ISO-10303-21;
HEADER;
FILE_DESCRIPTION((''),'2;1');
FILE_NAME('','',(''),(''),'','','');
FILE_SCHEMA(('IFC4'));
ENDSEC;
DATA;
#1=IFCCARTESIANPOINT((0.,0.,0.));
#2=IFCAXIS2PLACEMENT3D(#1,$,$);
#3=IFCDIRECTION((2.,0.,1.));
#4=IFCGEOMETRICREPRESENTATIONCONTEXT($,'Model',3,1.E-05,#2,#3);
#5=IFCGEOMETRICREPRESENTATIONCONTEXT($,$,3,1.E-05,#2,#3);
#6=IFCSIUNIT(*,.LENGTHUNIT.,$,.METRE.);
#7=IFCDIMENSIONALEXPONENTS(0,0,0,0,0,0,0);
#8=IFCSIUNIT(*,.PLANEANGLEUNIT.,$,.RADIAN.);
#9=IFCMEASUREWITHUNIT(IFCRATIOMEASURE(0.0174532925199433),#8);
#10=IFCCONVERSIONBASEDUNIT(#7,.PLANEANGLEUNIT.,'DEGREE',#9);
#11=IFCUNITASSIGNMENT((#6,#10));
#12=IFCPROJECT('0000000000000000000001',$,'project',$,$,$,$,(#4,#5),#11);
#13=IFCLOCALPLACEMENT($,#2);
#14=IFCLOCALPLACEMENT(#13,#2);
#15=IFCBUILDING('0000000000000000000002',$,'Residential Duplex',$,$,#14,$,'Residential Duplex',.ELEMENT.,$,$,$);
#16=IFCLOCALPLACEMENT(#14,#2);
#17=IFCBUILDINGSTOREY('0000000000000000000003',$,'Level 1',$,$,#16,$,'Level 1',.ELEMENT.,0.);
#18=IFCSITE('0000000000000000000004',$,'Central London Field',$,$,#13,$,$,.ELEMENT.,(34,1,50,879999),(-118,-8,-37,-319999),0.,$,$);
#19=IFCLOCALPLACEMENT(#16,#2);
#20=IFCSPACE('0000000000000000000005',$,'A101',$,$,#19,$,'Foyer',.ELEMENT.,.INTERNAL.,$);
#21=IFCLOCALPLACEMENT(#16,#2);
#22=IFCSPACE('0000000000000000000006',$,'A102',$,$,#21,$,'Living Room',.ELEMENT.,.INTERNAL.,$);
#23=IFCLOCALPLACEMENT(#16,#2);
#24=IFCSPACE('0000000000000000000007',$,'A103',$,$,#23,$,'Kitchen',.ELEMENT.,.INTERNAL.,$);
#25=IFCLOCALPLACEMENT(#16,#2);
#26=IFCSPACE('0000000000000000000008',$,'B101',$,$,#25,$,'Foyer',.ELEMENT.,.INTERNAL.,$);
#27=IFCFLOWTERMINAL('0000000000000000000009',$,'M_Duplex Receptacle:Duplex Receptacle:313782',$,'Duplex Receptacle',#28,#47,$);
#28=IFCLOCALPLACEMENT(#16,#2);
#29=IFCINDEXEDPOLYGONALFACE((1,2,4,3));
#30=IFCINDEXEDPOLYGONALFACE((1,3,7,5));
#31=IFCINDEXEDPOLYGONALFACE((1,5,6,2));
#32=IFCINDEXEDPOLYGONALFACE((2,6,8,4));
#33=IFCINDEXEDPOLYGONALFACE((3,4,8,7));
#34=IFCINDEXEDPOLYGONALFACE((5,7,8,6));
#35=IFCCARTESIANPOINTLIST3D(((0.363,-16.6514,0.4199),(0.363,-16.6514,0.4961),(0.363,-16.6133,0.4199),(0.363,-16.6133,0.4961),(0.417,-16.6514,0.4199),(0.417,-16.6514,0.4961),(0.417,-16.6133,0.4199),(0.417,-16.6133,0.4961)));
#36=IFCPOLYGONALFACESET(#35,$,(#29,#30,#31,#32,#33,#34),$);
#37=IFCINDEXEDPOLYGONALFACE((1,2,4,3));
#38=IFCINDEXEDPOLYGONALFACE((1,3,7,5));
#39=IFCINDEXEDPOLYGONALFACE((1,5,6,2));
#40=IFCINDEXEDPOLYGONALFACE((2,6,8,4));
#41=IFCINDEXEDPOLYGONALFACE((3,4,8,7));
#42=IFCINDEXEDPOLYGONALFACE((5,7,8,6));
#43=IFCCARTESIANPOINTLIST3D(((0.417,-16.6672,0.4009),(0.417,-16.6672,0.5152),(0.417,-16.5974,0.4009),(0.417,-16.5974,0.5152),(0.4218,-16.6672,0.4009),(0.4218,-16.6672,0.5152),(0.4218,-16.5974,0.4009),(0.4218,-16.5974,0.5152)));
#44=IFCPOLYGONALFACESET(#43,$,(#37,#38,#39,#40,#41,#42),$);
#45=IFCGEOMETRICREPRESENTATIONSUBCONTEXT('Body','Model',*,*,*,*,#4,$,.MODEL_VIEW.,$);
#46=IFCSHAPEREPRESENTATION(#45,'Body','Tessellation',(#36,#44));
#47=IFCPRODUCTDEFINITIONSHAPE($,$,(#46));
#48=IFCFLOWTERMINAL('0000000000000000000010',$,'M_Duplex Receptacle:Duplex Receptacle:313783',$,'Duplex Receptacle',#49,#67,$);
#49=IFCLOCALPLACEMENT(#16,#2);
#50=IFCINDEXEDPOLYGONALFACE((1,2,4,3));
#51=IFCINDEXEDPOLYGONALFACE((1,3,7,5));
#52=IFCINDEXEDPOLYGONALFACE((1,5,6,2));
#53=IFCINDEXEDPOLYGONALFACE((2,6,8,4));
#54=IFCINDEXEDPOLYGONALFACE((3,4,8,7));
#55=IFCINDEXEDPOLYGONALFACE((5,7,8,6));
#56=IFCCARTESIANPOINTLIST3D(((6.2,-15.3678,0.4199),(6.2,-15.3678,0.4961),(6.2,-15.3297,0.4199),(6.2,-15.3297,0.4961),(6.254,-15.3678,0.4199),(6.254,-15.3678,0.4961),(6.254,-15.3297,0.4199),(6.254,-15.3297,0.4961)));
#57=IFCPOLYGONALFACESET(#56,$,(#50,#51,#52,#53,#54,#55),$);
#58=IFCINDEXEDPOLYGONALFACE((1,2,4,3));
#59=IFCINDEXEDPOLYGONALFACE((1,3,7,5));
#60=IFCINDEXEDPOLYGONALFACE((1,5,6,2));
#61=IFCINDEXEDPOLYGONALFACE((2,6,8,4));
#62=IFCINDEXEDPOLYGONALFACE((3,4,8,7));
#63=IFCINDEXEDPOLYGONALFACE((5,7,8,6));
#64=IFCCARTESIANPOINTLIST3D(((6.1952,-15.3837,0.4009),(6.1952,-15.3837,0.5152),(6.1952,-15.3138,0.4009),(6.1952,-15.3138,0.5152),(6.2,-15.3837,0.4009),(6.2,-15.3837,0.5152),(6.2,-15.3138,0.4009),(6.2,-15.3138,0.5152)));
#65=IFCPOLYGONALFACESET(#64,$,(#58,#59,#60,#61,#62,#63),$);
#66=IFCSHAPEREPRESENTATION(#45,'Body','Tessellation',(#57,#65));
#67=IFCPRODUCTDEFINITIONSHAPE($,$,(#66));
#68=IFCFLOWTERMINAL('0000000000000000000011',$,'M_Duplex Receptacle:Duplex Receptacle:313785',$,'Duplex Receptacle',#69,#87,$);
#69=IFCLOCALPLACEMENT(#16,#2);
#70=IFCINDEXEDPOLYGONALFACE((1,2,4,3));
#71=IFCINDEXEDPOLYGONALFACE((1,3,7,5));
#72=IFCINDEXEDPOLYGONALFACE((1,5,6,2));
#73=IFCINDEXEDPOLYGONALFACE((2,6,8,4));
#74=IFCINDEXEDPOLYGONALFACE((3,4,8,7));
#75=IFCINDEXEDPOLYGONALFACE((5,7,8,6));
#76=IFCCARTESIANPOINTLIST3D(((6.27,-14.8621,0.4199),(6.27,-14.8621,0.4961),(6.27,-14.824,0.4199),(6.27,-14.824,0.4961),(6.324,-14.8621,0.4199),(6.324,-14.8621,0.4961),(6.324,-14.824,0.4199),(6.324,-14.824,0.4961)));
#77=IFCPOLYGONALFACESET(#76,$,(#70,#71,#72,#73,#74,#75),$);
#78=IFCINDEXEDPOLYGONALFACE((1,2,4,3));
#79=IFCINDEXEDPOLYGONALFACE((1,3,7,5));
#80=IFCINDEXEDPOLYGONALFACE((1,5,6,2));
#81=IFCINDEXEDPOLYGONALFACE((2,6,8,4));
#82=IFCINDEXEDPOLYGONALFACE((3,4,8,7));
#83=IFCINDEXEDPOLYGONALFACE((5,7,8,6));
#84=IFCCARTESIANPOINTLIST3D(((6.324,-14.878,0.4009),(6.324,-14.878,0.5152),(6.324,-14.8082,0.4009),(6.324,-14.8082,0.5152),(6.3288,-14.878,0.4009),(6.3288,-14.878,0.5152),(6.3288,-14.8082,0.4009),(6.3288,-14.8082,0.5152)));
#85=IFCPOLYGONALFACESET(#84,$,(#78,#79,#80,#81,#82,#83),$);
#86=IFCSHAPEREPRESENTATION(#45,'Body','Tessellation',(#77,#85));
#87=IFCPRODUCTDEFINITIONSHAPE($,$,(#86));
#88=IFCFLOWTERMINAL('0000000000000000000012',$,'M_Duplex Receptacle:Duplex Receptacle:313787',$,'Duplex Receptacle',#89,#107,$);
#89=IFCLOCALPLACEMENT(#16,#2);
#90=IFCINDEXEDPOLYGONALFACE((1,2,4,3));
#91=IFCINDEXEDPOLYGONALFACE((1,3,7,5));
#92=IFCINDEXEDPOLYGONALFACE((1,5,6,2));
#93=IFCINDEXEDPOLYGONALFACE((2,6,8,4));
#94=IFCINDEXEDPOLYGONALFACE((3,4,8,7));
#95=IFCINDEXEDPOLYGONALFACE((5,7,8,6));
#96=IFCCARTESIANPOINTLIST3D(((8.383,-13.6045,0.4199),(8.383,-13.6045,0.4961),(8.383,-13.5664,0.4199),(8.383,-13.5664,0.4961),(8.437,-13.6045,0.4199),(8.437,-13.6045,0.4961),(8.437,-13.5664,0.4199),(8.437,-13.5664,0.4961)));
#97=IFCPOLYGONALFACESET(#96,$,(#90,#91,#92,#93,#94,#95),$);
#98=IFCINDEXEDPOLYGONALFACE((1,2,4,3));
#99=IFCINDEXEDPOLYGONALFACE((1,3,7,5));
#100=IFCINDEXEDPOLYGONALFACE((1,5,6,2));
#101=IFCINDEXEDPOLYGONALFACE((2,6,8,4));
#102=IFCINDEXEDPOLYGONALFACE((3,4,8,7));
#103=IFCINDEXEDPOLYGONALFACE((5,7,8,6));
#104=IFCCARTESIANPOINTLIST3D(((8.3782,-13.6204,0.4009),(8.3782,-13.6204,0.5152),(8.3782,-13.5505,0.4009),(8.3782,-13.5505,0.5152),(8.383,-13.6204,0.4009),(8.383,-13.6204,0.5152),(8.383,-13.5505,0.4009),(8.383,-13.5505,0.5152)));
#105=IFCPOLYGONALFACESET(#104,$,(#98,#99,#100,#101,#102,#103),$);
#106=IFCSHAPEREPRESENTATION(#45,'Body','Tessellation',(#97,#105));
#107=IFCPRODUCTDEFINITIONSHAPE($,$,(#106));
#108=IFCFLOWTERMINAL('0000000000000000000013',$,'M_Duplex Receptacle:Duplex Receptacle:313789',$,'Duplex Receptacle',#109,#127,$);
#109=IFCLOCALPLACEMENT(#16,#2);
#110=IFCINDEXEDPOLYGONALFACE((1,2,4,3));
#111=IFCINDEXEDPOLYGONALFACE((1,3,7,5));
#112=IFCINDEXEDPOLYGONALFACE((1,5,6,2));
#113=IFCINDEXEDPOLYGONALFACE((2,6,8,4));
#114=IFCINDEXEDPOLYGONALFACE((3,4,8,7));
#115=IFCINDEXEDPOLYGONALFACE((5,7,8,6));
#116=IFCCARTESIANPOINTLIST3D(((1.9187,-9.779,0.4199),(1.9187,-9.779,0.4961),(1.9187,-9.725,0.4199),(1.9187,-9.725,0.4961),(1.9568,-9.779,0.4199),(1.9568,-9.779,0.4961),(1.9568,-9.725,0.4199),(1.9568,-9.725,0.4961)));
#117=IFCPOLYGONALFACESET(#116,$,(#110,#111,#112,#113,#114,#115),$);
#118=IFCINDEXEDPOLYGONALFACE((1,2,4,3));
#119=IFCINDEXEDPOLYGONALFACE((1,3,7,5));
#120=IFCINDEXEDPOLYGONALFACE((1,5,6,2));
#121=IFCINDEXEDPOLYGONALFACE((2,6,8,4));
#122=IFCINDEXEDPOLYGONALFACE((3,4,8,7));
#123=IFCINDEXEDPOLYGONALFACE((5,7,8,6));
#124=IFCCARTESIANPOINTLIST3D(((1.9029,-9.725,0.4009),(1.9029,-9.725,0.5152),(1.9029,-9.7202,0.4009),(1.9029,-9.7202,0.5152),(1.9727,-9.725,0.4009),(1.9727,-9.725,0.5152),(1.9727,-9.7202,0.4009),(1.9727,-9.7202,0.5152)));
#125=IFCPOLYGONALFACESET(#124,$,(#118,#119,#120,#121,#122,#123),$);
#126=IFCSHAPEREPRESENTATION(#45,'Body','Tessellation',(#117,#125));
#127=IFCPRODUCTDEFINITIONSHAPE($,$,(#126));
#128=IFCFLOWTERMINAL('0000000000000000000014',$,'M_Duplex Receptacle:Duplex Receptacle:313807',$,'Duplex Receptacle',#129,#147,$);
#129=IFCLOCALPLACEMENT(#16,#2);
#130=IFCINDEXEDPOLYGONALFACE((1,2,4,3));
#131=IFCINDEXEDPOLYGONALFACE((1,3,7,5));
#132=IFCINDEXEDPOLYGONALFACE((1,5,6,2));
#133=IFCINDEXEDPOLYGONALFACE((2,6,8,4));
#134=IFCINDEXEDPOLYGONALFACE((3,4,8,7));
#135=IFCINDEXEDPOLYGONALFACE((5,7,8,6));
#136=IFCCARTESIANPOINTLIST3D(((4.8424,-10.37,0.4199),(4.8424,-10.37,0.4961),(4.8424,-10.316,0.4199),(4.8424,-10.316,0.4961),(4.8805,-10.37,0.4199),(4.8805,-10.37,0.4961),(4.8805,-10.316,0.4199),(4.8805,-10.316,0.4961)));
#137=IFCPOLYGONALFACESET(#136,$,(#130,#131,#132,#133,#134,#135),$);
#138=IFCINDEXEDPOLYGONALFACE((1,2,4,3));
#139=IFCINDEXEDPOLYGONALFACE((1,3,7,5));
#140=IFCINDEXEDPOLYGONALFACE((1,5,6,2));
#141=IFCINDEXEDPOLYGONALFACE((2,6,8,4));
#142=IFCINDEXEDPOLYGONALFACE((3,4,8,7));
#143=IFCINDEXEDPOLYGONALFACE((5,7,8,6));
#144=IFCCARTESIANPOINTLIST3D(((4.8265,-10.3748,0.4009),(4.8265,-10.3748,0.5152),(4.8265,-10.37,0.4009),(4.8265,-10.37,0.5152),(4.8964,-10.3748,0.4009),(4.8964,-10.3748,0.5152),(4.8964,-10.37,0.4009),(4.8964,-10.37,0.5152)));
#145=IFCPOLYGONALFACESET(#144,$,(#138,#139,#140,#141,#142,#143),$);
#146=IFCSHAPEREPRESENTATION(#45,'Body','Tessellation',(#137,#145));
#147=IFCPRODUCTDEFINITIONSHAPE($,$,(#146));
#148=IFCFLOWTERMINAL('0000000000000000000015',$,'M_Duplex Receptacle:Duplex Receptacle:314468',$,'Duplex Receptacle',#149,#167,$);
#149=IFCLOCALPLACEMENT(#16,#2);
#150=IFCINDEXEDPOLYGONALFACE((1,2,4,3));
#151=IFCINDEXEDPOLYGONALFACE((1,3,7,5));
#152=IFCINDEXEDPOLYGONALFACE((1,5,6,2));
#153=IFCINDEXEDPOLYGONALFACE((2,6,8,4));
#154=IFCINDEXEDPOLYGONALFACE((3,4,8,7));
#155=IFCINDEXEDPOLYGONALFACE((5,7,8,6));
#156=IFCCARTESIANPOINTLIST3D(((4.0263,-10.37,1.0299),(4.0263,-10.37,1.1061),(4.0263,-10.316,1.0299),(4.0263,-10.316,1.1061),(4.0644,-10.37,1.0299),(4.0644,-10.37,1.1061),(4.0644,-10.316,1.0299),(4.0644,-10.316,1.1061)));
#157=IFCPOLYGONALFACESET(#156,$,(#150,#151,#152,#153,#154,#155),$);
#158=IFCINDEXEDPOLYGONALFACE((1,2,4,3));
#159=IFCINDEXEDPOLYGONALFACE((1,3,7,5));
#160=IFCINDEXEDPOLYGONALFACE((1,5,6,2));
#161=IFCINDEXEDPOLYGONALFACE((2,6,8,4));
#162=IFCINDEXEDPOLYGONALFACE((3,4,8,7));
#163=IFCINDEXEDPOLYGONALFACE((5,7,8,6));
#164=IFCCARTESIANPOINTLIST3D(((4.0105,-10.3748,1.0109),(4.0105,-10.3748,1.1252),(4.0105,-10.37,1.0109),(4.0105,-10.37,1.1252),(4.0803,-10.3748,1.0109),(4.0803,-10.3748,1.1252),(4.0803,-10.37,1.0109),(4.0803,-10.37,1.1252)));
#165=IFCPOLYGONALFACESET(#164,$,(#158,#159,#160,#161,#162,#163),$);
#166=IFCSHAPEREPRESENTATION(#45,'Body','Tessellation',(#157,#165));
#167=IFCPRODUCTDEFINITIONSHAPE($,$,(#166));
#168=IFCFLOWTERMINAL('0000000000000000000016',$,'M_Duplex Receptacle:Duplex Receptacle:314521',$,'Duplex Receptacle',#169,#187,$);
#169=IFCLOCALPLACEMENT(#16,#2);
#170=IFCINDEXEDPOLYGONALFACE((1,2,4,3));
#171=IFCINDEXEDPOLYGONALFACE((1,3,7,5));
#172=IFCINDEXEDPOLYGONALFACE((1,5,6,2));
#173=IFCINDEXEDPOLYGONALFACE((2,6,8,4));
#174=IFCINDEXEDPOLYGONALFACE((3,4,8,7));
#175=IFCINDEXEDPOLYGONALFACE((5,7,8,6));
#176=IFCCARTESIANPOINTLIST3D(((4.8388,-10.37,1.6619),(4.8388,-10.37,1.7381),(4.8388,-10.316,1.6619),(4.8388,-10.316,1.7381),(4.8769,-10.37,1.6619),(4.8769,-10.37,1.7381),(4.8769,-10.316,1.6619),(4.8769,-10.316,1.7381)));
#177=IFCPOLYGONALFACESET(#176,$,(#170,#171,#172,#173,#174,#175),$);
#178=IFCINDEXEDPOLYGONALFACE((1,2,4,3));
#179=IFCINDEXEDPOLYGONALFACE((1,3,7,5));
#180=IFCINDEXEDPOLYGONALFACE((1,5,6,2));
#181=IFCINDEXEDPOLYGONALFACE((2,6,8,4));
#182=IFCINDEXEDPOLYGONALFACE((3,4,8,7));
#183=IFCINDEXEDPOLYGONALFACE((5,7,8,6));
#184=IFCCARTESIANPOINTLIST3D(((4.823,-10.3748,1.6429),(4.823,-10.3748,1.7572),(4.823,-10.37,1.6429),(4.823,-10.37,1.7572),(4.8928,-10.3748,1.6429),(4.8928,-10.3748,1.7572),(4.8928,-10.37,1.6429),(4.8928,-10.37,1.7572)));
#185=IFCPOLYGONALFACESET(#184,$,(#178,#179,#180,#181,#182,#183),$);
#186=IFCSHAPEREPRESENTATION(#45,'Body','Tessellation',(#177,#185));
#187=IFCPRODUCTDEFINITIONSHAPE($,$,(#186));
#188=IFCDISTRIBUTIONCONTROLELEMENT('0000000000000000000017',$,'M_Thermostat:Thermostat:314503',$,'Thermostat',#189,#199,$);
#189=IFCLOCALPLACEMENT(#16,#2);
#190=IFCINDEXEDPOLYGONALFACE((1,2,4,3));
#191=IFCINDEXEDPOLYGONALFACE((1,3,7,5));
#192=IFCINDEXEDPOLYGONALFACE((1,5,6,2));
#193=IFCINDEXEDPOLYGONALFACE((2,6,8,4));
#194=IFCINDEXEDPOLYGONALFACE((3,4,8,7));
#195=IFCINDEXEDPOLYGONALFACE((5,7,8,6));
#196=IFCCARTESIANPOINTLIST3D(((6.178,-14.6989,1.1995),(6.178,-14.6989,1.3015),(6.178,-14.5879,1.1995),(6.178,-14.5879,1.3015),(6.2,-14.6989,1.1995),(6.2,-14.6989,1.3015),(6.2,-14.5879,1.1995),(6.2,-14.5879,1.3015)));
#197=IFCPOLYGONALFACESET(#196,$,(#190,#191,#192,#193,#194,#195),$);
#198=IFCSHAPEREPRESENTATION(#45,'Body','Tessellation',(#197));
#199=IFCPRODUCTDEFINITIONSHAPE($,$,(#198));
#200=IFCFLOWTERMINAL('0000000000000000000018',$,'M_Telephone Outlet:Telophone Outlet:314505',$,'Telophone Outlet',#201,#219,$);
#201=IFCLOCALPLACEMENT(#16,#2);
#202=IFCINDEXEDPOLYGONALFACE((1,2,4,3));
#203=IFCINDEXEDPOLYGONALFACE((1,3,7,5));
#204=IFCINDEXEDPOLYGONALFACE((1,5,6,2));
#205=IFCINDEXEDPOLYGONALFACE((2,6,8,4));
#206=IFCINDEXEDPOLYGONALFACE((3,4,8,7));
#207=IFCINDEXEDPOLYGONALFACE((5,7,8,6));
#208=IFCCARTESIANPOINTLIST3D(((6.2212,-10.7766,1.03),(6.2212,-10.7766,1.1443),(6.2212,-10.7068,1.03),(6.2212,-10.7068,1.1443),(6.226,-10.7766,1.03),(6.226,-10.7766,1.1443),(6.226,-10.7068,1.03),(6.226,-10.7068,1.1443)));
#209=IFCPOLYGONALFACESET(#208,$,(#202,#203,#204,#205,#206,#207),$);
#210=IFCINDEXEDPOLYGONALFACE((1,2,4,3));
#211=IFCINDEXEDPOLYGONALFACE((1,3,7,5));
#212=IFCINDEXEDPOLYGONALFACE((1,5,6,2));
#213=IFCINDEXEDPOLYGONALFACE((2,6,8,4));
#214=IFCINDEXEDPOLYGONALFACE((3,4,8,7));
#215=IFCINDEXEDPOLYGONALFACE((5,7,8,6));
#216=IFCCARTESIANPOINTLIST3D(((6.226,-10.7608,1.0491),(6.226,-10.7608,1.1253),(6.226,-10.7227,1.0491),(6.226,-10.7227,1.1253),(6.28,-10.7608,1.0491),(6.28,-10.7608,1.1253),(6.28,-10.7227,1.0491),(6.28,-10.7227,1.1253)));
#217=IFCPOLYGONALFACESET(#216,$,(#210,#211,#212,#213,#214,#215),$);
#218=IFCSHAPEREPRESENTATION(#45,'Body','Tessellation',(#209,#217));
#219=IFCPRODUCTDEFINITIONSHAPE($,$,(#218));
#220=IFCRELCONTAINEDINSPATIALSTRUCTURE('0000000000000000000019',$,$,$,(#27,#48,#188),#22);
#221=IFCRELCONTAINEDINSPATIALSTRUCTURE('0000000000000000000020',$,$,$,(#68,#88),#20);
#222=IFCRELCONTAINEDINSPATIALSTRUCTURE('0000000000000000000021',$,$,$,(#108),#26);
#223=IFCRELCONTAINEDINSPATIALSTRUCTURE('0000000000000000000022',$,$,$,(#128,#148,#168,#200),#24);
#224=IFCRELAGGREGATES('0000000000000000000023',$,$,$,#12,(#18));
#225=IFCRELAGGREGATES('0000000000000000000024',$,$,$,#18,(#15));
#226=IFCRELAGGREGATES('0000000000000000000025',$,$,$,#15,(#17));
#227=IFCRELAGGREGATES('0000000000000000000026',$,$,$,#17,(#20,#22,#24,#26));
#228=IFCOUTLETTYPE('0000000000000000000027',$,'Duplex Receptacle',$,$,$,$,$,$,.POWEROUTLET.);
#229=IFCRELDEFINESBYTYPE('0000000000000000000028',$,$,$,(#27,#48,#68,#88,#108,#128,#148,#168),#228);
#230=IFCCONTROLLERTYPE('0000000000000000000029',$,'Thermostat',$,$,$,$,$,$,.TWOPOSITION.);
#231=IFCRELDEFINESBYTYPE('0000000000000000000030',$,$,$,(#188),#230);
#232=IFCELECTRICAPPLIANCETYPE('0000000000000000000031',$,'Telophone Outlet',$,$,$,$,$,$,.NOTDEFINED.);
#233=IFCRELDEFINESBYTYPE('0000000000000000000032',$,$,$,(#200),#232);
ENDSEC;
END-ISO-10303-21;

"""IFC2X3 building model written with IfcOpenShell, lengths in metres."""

from ifc_helpers import new_model, entity, si_unit, converted_unit, direction, frame, frame_2d, origin, origin_2d_with_axis, place, context, subcontext, project, spatial, rectangle, extrude, source, transform, mapped, type_object, type_shapes, element, save


model = new_model("IFC2X3")

# Units and contexts
model_context = context("Model", 3, precision=1e-05, world=origin(), true_north=direction((2.0, 0.0, 1.0)))
context_of_model = context(None, 3, precision=1e-05, world=origin(), true_north=direction((2.0, 0.0, 1.0)))
body_context = subcontext(model_context, "Body", "Model", "MODEL_VIEW")
ifc_project = project(units=[si_unit("LENGTHUNIT", "METRE"), converted_unit("PLANEANGLEUNIT", "DEGREE", entity("IfcRatioMeasure", 0.0174532925199433), si_unit("PLANEANGLEUNIT", "RADIAN"), dimensions=[0, 0, 0, 0, 0, 0, 0])], contexts=[model_context, context_of_model])

# Site, building, storey, space
site_placement = place(None, origin())
site = spatial("IfcSite", under=ifc_project, at=site_placement, Name="Central London Field", CompositionType="ELEMENT", RefLatitude=(34, 1, 50, 879999), RefLongitude=(-118, -8, -37, -319999), RefElevation=0.0)
building_placement = place(site_placement, origin())
building = spatial("IfcBuilding", under=site, at=building_placement, Name="Residential Duplex", LongName="Residential Duplex", CompositionType="ELEMENT")
storey_placement = place(building_placement, origin())
storey = spatial("IfcBuildingStorey", under=building, at=storey_placement, Name="Level 1", LongName="Level 1", CompositionType="ELEMENT", Elevation=0.0)
space_1_placement = place(storey_placement, origin())
space_1 = spatial("IfcSpace", under=storey, at=space_1_placement, Name="A101", LongName="Foyer", CompositionType="ELEMENT", InteriorOrExteriorSpace="INTERNAL")

# Shared definitions
space_2_placement = place(storey_placement, origin())
space_2 = spatial("IfcSpace", under=storey, at=space_2_placement, Name="A102", LongName="Living Room", CompositionType="ELEMENT", InteriorOrExteriorSpace="INTERNAL")

# Shared definitions
outlet_type = type_object("IfcOutletType", Name="Duplex Receptacle", PredefinedType="POWEROUTLET")
shared_shape_1 = source(origin(), body_context, "Body", "SweptSolid", [
    extrude(rectangle(XDim=0.0381, YDim=0.0762, at=origin_2d_with_axis()), frame((0.0, 0.0, -0.054), z_axis=(0.0, 0.0, 1.0), x_axis=(-1.0, 0.0, 0.0)), (0.0, 0.0, 1.0), 0.054),
    extrude(rectangle(XDim=0.0698, YDim=0.1143, at=frame_2d((0.0, 0.0), x_axis=(1.0, 0.0))), frame((0.0, 0.0, 0.0), z_axis=(0.0, 0.0, 1.0), x_axis=(-1.0, 0.0, 0.0)), (0.0, 0.0, 1.0), 0.0048),
])
type_shapes(outlet_type, [shared_shape_1])

# Shared definitions
space_3_placement = place(storey_placement, origin())
space_3 = spatial("IfcSpace", under=storey, at=space_3_placement, Name="A103", LongName="Kitchen", CompositionType="ELEMENT", InteriorOrExteriorSpace="INTERNAL")

# Flow terminals
for number, where, z_axis, x_axis, name in (
    (1, (0.417, -16.6323, 0.458), (1.0, 0.0, 0.0), (0.0, 1.0, 0.0), "M_Duplex Receptacle:Duplex Receptacle:313782"),
    (2, (6.2, -15.3487, 0.458), (-1.0, 0.0, 0.0), (0.0, -1.0, 0.0), "M_Duplex Receptacle:Duplex Receptacle:313783"),
):
    element("IfcFlowTerminal", number, at=place(space_2_placement, frame(where, z_axis=z_axis, x_axis=x_axis)), inside=space_2, type_object=outlet_type, Name=name, ObjectType="Duplex Receptacle", context=body_context, shape_type="MappedRepresentation", body=[
        mapped(shared_shape_1, transform((0.0, 0.0, 0.0), scale=1.0)),
    ])
for number, where, z_axis, x_axis, name in (
    (3, (6.324, -14.8431, 0.458), (1.0, 0.0, 0.0), (0.0, 1.0, 0.0), "M_Duplex Receptacle:Duplex Receptacle:313785"),
    (4, (8.383, -13.5854, 0.458), (-1.0, 0.0, 0.0), (0.0, -1.0, 0.0), "M_Duplex Receptacle:Duplex Receptacle:313787"),
):
    element("IfcFlowTerminal", number, at=place(space_1_placement, frame(where, z_axis=z_axis, x_axis=x_axis)), inside=space_1, type_object=outlet_type, Name=name, ObjectType="Duplex Receptacle", context=body_context, shape_type="MappedRepresentation", body=[
        mapped(shared_shape_1, transform((0.0, 0.0, 0.0), scale=1.0)),
    ])

# Shared definitions
space_4_placement = place(storey_placement, origin())
space_4 = spatial("IfcSpace", under=storey, at=space_4_placement, Name="B101", LongName="Foyer", CompositionType="ELEMENT", InteriorOrExteriorSpace="INTERNAL")

# Flow terminals
flow_terminal_1_placement = place(space_4_placement, frame((1.9378, -9.725, 0.458), z_axis=(0.0, 1.0, 0.0), x_axis=(-1.0, 0.0, 0.0)))
element("IfcFlowTerminal", 5, at=flow_terminal_1_placement, inside=space_4, type_object=outlet_type, Name="M_Duplex Receptacle:Duplex Receptacle:313789", ObjectType="Duplex Receptacle", context=body_context, shape_type="MappedRepresentation", body=[
    mapped(shared_shape_1, transform((0.0, 0.0, 0.0), scale=1.0)),
])
for number, where, z_axis, x_axis, name in (
    (6, (4.8615, -10.37, 0.458), (0.0, -1.0, 0.0), (1.0, 0.0, 0.0), "M_Duplex Receptacle:Duplex Receptacle:313807"),
    (7, (4.0454, -10.37, 1.068), (0.0, -1.0, 0.0), (1.0, 0.0, 0.0), "M_Duplex Receptacle:Duplex Receptacle:314468"),
    (8, (4.8579, -10.37, 1.7), (0.0, -1.0, 0.0), (1.0, 0.0, 0.0), "M_Duplex Receptacle:Duplex Receptacle:314521"),
):
    element("IfcFlowTerminal", number, at=place(space_3_placement, frame(where, z_axis=z_axis, x_axis=x_axis)), inside=space_3, type_object=outlet_type, Name=name, ObjectType="Duplex Receptacle", context=body_context, shape_type="MappedRepresentation", body=[
        mapped(shared_shape_1, transform((0.0, 0.0, 0.0), scale=1.0)),
    ])

# Distribution control element
controller_type = type_object("IfcControllerType", Name="Thermostat", PredefinedType="TWOPOSITION")
shared_shape_2 = source(origin(), body_context, "Body", "SweptSolid", [
    extrude(rectangle(XDim=0.102, YDim=0.111, at=origin_2d_with_axis()), frame((0.0, -0.051, 0.0), z_axis=(0.0, 0.0, 1.0), x_axis=(0.0, 1.0, 0.0)), (0.0, 0.0, 1.0), 0.022),
])
type_shapes(controller_type, [shared_shape_2])
distribution_control_element_placement = place(space_2_placement, frame((6.2, -14.6434, 1.3015), z_axis=(-1.0, 0.0, 0.0), x_axis=(0.0, -1.0, 0.0)))
element("IfcDistributionControlElement", 9, at=distribution_control_element_placement, inside=space_2, type_object=controller_type, Name="M_Thermostat:Thermostat:314503", ObjectType="Thermostat", context=body_context, shape_type="MappedRepresentation", body=[
    mapped(shared_shape_2, transform((0.0, 0.0, 0.0), scale=1.0)),
])

# Flow terminal
electric_appliance_type = type_object("IfcElectricApplianceType", Name="Telophone Outlet", PredefinedType="NOTDEFINED")
shared_shape_3 = source(origin(), body_context, "Body", "SweptSolid", [
    extrude(rectangle(XDim=0.0699, YDim=0.1143, at=frame_2d((0.0, 0.0), x_axis=(1.0, 0.0))), frame((0.0, 0.0, 0.0), z_axis=(0.0, 0.0, 1.0), x_axis=(-1.0, 0.0, 0.0)), (0.0, 0.0, 1.0), 0.0048),
    extrude(rectangle(XDim=0.0381, YDim=0.0762, at=origin_2d_with_axis()), frame((0.0, 0.0, -0.054), z_axis=(0.0, 0.0, 1.0), x_axis=(-1.0, 0.0, 0.0)), (0.0, 0.0, 1.0), 0.054),
])
type_shapes(electric_appliance_type, [shared_shape_3])
flow_terminal_2_placement = place(space_3_placement, frame((6.226, -10.7417, 1.0872), z_axis=(-1.0, 0.0, 0.0), x_axis=(0.0, -1.0, 0.0)))
element("IfcFlowTerminal", 10, at=flow_terminal_2_placement, inside=space_3, type_object=electric_appliance_type, Name="M_Telephone Outlet:Telophone Outlet:314505", ObjectType="Telophone Outlet", context=body_context, shape_type="MappedRepresentation", body=[
    mapped(shared_shape_3, transform((0.0, 0.0, 0.0), scale=1.0)),
])

save(model, "model.ifc")
